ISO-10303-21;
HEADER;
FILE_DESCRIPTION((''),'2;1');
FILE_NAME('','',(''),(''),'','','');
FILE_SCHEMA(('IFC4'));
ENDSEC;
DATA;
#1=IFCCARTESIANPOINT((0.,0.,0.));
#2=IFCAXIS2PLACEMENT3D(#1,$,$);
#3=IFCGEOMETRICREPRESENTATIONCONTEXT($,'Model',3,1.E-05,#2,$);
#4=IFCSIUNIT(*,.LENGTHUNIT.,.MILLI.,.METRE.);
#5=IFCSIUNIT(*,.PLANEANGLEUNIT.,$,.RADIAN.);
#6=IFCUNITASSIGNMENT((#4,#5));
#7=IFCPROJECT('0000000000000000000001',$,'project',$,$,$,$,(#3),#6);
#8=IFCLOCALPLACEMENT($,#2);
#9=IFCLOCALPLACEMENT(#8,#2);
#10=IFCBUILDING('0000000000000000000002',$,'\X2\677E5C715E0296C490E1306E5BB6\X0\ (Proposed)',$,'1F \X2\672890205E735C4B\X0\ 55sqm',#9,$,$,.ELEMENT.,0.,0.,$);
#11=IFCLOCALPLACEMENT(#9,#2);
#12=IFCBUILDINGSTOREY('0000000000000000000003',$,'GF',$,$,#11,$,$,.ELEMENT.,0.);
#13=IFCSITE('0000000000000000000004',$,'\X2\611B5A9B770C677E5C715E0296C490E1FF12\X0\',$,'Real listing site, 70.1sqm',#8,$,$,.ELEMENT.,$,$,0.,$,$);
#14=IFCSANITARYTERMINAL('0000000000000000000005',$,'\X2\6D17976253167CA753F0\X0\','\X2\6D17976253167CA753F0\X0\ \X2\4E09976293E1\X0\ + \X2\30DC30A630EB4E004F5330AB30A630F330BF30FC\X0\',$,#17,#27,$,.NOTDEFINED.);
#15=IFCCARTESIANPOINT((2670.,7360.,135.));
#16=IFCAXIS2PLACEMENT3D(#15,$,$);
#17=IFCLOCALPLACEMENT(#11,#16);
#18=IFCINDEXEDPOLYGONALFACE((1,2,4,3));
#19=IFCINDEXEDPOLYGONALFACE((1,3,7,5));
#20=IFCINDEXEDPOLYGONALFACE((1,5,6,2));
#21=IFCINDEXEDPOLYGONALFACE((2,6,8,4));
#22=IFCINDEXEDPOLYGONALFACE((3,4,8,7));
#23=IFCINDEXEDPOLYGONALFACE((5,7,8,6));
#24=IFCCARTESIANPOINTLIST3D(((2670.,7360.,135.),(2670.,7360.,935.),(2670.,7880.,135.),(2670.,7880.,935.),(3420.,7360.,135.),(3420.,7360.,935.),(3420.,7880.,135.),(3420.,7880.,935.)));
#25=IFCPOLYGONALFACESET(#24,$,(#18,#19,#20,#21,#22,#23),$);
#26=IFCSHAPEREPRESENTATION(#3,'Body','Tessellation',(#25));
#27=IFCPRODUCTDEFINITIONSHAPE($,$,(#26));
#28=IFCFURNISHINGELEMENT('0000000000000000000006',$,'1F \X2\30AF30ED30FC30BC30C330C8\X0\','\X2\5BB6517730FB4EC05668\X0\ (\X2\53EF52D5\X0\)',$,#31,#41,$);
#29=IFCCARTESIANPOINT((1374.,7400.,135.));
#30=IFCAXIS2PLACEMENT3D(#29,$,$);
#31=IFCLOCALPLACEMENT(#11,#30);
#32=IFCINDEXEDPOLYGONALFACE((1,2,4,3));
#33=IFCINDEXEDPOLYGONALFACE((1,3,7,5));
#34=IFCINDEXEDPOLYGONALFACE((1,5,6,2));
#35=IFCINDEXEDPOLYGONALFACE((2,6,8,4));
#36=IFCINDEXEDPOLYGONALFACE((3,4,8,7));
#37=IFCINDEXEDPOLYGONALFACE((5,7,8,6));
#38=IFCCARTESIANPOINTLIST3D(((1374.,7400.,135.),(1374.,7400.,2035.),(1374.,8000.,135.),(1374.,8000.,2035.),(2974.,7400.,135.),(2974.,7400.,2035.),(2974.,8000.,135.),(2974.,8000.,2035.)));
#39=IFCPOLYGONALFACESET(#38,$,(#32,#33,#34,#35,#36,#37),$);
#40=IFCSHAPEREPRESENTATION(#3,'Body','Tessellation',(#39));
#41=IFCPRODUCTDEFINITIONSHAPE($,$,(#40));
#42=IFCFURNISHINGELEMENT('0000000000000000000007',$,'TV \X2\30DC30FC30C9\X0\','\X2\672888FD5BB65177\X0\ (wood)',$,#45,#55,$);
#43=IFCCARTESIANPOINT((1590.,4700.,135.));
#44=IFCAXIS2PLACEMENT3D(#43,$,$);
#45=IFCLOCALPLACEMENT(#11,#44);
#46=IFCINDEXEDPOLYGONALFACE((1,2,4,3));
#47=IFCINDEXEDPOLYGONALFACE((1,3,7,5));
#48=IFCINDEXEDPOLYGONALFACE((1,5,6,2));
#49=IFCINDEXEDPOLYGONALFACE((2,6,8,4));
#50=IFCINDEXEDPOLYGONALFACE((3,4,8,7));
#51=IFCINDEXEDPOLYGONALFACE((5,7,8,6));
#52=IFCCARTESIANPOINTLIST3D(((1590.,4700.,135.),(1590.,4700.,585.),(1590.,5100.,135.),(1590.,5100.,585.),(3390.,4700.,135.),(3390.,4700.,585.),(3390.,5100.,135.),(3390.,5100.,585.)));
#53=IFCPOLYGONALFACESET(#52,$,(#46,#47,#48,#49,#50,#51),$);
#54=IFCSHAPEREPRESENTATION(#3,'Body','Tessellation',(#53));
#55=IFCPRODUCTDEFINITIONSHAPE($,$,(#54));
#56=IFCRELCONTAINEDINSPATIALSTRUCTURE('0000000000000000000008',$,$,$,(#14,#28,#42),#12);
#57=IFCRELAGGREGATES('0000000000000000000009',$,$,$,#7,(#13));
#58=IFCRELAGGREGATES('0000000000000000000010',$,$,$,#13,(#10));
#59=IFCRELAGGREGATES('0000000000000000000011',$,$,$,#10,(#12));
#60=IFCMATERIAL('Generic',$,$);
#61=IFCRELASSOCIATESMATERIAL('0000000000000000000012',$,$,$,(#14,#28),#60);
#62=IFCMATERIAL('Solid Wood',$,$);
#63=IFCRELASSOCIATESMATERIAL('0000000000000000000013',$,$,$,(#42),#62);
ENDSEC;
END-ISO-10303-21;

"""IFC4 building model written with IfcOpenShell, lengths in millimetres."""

from ifc_helpers import new_model, si_unit, frame, frame_2d, origin, place, context, project, spatial, rectangle, extrude, material, element, save


model = new_model("IFC4")

# Units and contexts
model_context = context("Model", 3, precision=1e-05, world=origin())
ifc_project = project(units=[si_unit("LENGTHUNIT", "METRE", prefix="MILLI"), si_unit("PLANEANGLEUNIT", "RADIAN")], contexts=[model_context])

# Site, building, storey
site_placement = place(None, origin())
site = spatial("IfcSite", under=ifc_project, at=site_placement, Name="愛媛県松山市雄郡２", ObjectType="Real listing site, 70.1sqm", CompositionType="ELEMENT", RefElevation=0.0)
building_placement = place(site_placement, origin())
building = spatial("IfcBuilding", under=site, at=building_placement, Name="松山市雄郡の家 (Proposed)", ObjectType="1F 木造平屋 55sqm", CompositionType="ELEMENT", ElevationOfRefHeight=0.0, ElevationOfTerrain=0.0)
storey_placement = place(building_placement, origin())
storey = spatial("IfcBuildingStorey", under=building, at=storey_placement, Name="GF", CompositionType="ELEMENT", Elevation=0.0)

# Shared definitions
ifc_material_1 = material(Name="Solid Wood")

# Shared definitions
ifc_material_2 = material(Name="Generic")

# Sanitary terminal
sanitary_terminal_1_placement = place(storey_placement, frame((2670.0, 7360.0, 135.0)))
element("IfcSanitaryTerminal", 1, at=sanitary_terminal_1_placement, inside=storey, material=ifc_material_2, Name="洗面化粧台", Description="洗面化粧台 三面鏡 + ボウル一体カウンター", PredefinedType="NOTDEFINED", context=model_context, shape_type="SweptSolid", body=[
    extrude(rectangle(XDim=750.0, YDim=520.0, at=frame_2d((375.0, 260.0))), frame((2670.0, 7360.0, 135.0)), (0.0, 0.0, 1.0), 800.0),
])

# Furnishing elements
furnishing_1_placement = place(storey_placement, frame((1374.0, 7400.0, 135.0)))
element("IfcFurnishingElement", 2, at=furnishing_1_placement, inside=storey, material=ifc_material_2, Name="1F クローゼット", Description="家具・什器 (可動)", context=model_context, shape_type="SweptSolid", body=[
    extrude(rectangle(XDim=1600.0, YDim=600.0, at=frame_2d((800.0, 300.0))), frame((1374.0, 7400.0, 135.0)), (0.0, 0.0, 1.0), 1900.0),
])
furnishing_2_placement = place(storey_placement, frame((1590.0, 4700.0, 135.0)))
element("IfcFurnishingElement", 3, at=furnishing_2_placement, inside=storey, material=ifc_material_1, Name="TV ボード", Description="木製家具 (wood)", context=model_context, shape_type="SweptSolid", body=[
    extrude(rectangle(XDim=1800.0, YDim=400.0, at=frame_2d((900.0, 200.0))), frame((1590.0, 4700.0, 135.0)), (0.0, 0.0, 1.0), 450.0),
])

save(model, "model.ifc")
